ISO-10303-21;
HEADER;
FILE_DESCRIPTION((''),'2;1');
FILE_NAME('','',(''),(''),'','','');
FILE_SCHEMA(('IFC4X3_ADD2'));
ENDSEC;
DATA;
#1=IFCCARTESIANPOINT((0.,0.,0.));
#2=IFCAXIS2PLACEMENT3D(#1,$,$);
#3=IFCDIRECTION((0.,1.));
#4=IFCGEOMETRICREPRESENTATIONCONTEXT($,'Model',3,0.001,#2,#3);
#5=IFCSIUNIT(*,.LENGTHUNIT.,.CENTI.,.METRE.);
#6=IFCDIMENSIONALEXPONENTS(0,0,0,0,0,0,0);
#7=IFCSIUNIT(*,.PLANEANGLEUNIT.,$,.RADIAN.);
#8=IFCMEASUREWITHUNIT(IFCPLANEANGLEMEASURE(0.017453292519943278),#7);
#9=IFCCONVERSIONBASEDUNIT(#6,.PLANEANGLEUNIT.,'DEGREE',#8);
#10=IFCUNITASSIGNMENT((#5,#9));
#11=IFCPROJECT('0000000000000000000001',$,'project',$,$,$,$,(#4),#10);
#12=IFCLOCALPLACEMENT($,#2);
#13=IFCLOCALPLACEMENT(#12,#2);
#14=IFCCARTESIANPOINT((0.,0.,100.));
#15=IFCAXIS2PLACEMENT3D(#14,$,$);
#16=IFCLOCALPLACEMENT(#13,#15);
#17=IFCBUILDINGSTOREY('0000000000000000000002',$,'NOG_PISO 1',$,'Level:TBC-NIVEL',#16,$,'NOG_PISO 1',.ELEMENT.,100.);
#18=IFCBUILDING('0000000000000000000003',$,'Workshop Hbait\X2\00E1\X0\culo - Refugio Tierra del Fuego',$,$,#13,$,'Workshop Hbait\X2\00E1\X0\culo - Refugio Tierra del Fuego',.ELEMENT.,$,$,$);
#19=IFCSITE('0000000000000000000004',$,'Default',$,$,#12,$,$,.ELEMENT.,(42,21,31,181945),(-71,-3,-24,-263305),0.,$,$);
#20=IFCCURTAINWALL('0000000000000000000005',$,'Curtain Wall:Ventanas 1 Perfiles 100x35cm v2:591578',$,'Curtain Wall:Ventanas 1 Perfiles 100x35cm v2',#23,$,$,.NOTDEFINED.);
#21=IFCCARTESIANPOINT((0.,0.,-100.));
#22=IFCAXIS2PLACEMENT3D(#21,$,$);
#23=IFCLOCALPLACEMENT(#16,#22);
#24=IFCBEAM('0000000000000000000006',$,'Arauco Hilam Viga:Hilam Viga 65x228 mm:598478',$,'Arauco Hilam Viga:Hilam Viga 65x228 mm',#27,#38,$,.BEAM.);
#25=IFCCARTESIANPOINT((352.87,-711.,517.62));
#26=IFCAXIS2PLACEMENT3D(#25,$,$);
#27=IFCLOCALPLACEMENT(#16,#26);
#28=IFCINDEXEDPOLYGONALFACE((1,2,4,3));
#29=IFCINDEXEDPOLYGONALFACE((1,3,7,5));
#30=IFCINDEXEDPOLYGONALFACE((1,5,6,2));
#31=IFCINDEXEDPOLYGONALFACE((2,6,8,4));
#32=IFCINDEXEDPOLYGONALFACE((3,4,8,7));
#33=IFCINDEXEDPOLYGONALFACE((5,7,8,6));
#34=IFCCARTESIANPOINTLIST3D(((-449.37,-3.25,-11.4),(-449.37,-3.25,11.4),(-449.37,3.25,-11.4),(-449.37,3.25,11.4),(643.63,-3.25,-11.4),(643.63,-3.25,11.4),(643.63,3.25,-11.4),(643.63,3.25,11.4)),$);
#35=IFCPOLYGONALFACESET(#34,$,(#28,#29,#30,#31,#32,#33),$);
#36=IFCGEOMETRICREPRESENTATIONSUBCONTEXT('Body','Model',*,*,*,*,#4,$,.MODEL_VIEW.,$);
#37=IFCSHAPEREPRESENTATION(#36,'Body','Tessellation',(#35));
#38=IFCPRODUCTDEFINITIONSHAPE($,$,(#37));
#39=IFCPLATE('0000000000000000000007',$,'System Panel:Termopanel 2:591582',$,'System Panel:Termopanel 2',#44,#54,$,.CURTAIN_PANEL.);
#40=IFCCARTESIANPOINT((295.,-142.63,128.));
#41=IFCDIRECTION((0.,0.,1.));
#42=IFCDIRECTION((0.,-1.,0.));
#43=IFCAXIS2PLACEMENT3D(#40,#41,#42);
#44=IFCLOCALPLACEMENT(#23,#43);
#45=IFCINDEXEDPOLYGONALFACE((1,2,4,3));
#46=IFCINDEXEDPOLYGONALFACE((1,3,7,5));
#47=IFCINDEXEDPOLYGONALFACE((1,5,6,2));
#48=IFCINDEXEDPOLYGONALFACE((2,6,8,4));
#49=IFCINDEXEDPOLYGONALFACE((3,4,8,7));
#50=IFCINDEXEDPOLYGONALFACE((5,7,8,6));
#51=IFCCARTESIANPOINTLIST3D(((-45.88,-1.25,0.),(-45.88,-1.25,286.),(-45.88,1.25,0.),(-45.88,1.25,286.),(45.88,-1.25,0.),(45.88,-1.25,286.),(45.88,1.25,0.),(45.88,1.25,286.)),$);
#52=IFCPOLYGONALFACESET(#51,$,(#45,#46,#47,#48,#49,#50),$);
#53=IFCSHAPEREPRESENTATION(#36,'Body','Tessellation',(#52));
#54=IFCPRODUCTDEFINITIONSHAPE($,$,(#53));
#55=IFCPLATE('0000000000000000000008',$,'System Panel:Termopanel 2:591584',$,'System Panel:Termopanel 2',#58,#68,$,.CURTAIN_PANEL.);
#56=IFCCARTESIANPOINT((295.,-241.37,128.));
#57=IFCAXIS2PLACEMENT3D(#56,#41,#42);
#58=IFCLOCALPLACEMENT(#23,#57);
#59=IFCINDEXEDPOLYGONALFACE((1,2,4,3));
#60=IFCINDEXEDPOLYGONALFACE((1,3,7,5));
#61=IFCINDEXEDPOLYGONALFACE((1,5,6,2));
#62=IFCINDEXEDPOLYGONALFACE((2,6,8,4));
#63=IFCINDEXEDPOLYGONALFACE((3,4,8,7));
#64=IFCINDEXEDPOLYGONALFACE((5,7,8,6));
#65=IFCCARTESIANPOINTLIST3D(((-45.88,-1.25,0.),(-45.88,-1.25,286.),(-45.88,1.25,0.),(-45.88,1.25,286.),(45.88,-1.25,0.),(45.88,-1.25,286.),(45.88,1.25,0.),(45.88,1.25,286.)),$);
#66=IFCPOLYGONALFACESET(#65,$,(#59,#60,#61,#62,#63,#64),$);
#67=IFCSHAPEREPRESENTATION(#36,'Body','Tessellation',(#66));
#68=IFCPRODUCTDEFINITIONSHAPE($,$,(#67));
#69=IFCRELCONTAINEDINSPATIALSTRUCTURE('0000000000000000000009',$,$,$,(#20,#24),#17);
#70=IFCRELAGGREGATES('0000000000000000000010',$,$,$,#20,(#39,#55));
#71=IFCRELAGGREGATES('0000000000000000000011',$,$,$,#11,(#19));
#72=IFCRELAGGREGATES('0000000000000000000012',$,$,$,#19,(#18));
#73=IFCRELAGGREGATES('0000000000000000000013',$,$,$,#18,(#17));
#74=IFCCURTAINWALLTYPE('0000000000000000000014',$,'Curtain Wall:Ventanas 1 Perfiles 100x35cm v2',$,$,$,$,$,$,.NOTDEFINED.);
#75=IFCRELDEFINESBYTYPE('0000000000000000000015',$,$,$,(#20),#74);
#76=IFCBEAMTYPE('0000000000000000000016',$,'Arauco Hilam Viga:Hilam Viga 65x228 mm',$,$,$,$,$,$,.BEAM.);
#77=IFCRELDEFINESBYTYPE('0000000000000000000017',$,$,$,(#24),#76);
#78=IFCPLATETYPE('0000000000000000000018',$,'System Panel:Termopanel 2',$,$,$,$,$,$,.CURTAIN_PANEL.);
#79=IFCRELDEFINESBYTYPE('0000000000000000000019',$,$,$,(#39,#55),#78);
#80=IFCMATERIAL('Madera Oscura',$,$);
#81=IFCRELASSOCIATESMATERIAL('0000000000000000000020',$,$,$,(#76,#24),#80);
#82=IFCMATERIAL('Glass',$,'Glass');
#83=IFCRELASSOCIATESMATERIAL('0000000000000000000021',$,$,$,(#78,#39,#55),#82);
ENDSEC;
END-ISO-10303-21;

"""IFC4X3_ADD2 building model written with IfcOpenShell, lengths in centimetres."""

from ifc_helpers import new_model, entity, si_unit, converted_unit, direction, frame, frame_2d, origin, origin_2d_with_axis, place, context, subcontext, project, spatial, rectangle, extrude, source, transform, mapped, material, material_profile, profile_set, profile_usage, type_object, type_shapes, element, aggregate, save


model = new_model("IFC4X3_ADD2")

# Units and contexts
model_context = context("Model", 3, precision=0.001, world=origin(), true_north=direction((0.0, 1.0)))
body_context = subcontext(model_context, "Body", "Model", "MODEL_VIEW")
ifc_project = project(units=[si_unit("LENGTHUNIT", "METRE", prefix="CENTI"), converted_unit("PLANEANGLEUNIT", "DEGREE", entity("IfcPlaneAngleMeasure", 0.017453292519943278), si_unit("PLANEANGLEUNIT", "RADIAN"), dimensions=[0, 0, 0, 0, 0, 0, 0])], contexts=[model_context])

# Site, building, storey
site_placement = place(None, origin())
site = spatial("IfcSite", under=ifc_project, at=site_placement, Name="Default", CompositionType="ELEMENT", RefLatitude=(42, 21, 31, 181945), RefLongitude=(-71, -3, -24, -263305), RefElevation=0.0)
building_placement = place(site_placement, origin())
building = spatial("IfcBuilding", under=site, at=building_placement, Name="Workshop Hbaitáculo - Refugio Tierra del Fuego", LongName="Workshop Hbaitáculo - Refugio Tierra del Fuego", CompositionType="ELEMENT")
storey_placement = place(building_placement, frame((0.0, 0.0, 100.0)))
storey = spatial("IfcBuildingStorey", under=building, at=storey_placement, Name="NOG_PISO 1", ObjectType="Level:TBC-NIVEL", LongName="NOG_PISO 1", CompositionType="ELEMENT", Elevation=100.0)

# Shared definitions
ifc_material_1 = material(Name="Madera Oscura")
ifc_material_profile_1 = material_profile(ifc_material_1, rectangle(XDim=930.0, YDim=6.5, at=origin_2d_with_axis()), Name="Hilam Viga 65x228 mm")
ifc_profile_set_1 = profile_set([ifc_material_profile_1], Name="Hilam Viga 65x228 mm")
ifc_profile_usage_1 = profile_usage(ifc_profile_set_1, cardinal=8)

# Curtain wall
curtain_wall_type = type_object("IfcCurtainWallType", Name="Curtain Wall:Ventanas 1 Perfiles 100x35cm v2", PredefinedType="NOTDEFINED")
curtain_wall_placement = place(storey_placement, frame((0.0, 0.0, -100.0)))
curtain_wall = element("IfcCurtainWall", 1, at=curtain_wall_placement, inside=storey, type_object=curtain_wall_type, Name="Curtain Wall:Ventanas 1 Perfiles 100x35cm v2:591578", ObjectType="Curtain Wall:Ventanas 1 Perfiles 100x35cm v2", PredefinedType="NOTDEFINED")

# Beam
beam_type_1 = type_object("IfcBeamType", Name="Arauco Hilam Viga:Hilam Viga 65x228 mm", PredefinedType="BEAM", material=ifc_profile_set_1)
shared_shape_1 = source(origin(), body_context, "Body", "SweptSolid", [
    extrude(rectangle(XDim=6.5, YDim=1093.0, at=origin_2d_with_axis()), frame((97.13, 0.0, -11.4), z_axis=(0.0, 0.0, 1.0), x_axis=(0.0, 1.0, 0.0)), (0.0, 0.0, 1.0), 22.8),
])
type_shapes(beam_type_1, [shared_shape_1])
for number, where, name in (
    (2, (352.87, -711.0, 517.62), "Arauco Hilam Viga:Hilam Viga 65x228 mm:598478"),
):
    element("IfcBeam", number, at=place(storey_placement, frame(where)), inside=storey, type_object=beam_type_1, material=ifc_profile_usage_1, Name=name, ObjectType="Arauco Hilam Viga:Hilam Viga 65x228 mm", PredefinedType="BEAM", context=body_context, shape_type="MappedRepresentation", body=[
        mapped(shared_shape_1, transform((0.0, 0.0, 0.0), scale=1.0)),
    ])

# Plates
ifc_material_2 = material(Name="Glass", Category="Glass")
plate_type = type_object("IfcPlateType", Name="System Panel:Termopanel 2", PredefinedType="CURTAIN_PANEL", material=ifc_material_2)
shared_shape_2 = source(origin(), body_context, "Body", "SweptSolid", [
    extrude(rectangle(XDim=2.5, YDim=91.75, at=frame_2d((0.0, 0.0), x_axis=(1.0, 0.0))), frame((0.0, 0.0, 0.0), z_axis=(0.0, 0.0, 1.0), x_axis=(0.0, 1.0, 0.0)), (0.0, 0.0, 1.0), 286.0),
])
type_shapes(plate_type, [shared_shape_2])
plate_1_placement = place(curtain_wall_placement, frame((295.0, -142.63, 128.0), z_axis=(0.0, 0.0, 1.0), x_axis=(0.0, -1.0, 0.0)))
plate_1 = element("IfcPlate", 3, at=plate_1_placement, type_object=plate_type, material=ifc_material_2, Name="System Panel:Termopanel 2:591582", ObjectType="System Panel:Termopanel 2", PredefinedType="CURTAIN_PANEL", context=body_context, shape_type="MappedRepresentation", body=[
    mapped(shared_shape_2, transform((0.0, 0.0, 0.0), scale=1.0)),
])
plate_2_placement = place(curtain_wall_placement, frame((295.0, -241.37, 128.0), z_axis=(0.0, 0.0, 1.0), x_axis=(0.0, -1.0, 0.0)))
plate_2 = element("IfcPlate", 4, at=plate_2_placement, type_object=plate_type, material=ifc_material_2, Name="System Panel:Termopanel 2:591584", ObjectType="System Panel:Termopanel 2", PredefinedType="CURTAIN_PANEL", context=body_context, shape_type="MappedRepresentation", body=[
    mapped(shared_shape_2, transform((0.0, 0.0, 0.0), scale=1.0)),
])
aggregate(curtain_wall, [plate_1, plate_2])

save(model, "model.ifc")
